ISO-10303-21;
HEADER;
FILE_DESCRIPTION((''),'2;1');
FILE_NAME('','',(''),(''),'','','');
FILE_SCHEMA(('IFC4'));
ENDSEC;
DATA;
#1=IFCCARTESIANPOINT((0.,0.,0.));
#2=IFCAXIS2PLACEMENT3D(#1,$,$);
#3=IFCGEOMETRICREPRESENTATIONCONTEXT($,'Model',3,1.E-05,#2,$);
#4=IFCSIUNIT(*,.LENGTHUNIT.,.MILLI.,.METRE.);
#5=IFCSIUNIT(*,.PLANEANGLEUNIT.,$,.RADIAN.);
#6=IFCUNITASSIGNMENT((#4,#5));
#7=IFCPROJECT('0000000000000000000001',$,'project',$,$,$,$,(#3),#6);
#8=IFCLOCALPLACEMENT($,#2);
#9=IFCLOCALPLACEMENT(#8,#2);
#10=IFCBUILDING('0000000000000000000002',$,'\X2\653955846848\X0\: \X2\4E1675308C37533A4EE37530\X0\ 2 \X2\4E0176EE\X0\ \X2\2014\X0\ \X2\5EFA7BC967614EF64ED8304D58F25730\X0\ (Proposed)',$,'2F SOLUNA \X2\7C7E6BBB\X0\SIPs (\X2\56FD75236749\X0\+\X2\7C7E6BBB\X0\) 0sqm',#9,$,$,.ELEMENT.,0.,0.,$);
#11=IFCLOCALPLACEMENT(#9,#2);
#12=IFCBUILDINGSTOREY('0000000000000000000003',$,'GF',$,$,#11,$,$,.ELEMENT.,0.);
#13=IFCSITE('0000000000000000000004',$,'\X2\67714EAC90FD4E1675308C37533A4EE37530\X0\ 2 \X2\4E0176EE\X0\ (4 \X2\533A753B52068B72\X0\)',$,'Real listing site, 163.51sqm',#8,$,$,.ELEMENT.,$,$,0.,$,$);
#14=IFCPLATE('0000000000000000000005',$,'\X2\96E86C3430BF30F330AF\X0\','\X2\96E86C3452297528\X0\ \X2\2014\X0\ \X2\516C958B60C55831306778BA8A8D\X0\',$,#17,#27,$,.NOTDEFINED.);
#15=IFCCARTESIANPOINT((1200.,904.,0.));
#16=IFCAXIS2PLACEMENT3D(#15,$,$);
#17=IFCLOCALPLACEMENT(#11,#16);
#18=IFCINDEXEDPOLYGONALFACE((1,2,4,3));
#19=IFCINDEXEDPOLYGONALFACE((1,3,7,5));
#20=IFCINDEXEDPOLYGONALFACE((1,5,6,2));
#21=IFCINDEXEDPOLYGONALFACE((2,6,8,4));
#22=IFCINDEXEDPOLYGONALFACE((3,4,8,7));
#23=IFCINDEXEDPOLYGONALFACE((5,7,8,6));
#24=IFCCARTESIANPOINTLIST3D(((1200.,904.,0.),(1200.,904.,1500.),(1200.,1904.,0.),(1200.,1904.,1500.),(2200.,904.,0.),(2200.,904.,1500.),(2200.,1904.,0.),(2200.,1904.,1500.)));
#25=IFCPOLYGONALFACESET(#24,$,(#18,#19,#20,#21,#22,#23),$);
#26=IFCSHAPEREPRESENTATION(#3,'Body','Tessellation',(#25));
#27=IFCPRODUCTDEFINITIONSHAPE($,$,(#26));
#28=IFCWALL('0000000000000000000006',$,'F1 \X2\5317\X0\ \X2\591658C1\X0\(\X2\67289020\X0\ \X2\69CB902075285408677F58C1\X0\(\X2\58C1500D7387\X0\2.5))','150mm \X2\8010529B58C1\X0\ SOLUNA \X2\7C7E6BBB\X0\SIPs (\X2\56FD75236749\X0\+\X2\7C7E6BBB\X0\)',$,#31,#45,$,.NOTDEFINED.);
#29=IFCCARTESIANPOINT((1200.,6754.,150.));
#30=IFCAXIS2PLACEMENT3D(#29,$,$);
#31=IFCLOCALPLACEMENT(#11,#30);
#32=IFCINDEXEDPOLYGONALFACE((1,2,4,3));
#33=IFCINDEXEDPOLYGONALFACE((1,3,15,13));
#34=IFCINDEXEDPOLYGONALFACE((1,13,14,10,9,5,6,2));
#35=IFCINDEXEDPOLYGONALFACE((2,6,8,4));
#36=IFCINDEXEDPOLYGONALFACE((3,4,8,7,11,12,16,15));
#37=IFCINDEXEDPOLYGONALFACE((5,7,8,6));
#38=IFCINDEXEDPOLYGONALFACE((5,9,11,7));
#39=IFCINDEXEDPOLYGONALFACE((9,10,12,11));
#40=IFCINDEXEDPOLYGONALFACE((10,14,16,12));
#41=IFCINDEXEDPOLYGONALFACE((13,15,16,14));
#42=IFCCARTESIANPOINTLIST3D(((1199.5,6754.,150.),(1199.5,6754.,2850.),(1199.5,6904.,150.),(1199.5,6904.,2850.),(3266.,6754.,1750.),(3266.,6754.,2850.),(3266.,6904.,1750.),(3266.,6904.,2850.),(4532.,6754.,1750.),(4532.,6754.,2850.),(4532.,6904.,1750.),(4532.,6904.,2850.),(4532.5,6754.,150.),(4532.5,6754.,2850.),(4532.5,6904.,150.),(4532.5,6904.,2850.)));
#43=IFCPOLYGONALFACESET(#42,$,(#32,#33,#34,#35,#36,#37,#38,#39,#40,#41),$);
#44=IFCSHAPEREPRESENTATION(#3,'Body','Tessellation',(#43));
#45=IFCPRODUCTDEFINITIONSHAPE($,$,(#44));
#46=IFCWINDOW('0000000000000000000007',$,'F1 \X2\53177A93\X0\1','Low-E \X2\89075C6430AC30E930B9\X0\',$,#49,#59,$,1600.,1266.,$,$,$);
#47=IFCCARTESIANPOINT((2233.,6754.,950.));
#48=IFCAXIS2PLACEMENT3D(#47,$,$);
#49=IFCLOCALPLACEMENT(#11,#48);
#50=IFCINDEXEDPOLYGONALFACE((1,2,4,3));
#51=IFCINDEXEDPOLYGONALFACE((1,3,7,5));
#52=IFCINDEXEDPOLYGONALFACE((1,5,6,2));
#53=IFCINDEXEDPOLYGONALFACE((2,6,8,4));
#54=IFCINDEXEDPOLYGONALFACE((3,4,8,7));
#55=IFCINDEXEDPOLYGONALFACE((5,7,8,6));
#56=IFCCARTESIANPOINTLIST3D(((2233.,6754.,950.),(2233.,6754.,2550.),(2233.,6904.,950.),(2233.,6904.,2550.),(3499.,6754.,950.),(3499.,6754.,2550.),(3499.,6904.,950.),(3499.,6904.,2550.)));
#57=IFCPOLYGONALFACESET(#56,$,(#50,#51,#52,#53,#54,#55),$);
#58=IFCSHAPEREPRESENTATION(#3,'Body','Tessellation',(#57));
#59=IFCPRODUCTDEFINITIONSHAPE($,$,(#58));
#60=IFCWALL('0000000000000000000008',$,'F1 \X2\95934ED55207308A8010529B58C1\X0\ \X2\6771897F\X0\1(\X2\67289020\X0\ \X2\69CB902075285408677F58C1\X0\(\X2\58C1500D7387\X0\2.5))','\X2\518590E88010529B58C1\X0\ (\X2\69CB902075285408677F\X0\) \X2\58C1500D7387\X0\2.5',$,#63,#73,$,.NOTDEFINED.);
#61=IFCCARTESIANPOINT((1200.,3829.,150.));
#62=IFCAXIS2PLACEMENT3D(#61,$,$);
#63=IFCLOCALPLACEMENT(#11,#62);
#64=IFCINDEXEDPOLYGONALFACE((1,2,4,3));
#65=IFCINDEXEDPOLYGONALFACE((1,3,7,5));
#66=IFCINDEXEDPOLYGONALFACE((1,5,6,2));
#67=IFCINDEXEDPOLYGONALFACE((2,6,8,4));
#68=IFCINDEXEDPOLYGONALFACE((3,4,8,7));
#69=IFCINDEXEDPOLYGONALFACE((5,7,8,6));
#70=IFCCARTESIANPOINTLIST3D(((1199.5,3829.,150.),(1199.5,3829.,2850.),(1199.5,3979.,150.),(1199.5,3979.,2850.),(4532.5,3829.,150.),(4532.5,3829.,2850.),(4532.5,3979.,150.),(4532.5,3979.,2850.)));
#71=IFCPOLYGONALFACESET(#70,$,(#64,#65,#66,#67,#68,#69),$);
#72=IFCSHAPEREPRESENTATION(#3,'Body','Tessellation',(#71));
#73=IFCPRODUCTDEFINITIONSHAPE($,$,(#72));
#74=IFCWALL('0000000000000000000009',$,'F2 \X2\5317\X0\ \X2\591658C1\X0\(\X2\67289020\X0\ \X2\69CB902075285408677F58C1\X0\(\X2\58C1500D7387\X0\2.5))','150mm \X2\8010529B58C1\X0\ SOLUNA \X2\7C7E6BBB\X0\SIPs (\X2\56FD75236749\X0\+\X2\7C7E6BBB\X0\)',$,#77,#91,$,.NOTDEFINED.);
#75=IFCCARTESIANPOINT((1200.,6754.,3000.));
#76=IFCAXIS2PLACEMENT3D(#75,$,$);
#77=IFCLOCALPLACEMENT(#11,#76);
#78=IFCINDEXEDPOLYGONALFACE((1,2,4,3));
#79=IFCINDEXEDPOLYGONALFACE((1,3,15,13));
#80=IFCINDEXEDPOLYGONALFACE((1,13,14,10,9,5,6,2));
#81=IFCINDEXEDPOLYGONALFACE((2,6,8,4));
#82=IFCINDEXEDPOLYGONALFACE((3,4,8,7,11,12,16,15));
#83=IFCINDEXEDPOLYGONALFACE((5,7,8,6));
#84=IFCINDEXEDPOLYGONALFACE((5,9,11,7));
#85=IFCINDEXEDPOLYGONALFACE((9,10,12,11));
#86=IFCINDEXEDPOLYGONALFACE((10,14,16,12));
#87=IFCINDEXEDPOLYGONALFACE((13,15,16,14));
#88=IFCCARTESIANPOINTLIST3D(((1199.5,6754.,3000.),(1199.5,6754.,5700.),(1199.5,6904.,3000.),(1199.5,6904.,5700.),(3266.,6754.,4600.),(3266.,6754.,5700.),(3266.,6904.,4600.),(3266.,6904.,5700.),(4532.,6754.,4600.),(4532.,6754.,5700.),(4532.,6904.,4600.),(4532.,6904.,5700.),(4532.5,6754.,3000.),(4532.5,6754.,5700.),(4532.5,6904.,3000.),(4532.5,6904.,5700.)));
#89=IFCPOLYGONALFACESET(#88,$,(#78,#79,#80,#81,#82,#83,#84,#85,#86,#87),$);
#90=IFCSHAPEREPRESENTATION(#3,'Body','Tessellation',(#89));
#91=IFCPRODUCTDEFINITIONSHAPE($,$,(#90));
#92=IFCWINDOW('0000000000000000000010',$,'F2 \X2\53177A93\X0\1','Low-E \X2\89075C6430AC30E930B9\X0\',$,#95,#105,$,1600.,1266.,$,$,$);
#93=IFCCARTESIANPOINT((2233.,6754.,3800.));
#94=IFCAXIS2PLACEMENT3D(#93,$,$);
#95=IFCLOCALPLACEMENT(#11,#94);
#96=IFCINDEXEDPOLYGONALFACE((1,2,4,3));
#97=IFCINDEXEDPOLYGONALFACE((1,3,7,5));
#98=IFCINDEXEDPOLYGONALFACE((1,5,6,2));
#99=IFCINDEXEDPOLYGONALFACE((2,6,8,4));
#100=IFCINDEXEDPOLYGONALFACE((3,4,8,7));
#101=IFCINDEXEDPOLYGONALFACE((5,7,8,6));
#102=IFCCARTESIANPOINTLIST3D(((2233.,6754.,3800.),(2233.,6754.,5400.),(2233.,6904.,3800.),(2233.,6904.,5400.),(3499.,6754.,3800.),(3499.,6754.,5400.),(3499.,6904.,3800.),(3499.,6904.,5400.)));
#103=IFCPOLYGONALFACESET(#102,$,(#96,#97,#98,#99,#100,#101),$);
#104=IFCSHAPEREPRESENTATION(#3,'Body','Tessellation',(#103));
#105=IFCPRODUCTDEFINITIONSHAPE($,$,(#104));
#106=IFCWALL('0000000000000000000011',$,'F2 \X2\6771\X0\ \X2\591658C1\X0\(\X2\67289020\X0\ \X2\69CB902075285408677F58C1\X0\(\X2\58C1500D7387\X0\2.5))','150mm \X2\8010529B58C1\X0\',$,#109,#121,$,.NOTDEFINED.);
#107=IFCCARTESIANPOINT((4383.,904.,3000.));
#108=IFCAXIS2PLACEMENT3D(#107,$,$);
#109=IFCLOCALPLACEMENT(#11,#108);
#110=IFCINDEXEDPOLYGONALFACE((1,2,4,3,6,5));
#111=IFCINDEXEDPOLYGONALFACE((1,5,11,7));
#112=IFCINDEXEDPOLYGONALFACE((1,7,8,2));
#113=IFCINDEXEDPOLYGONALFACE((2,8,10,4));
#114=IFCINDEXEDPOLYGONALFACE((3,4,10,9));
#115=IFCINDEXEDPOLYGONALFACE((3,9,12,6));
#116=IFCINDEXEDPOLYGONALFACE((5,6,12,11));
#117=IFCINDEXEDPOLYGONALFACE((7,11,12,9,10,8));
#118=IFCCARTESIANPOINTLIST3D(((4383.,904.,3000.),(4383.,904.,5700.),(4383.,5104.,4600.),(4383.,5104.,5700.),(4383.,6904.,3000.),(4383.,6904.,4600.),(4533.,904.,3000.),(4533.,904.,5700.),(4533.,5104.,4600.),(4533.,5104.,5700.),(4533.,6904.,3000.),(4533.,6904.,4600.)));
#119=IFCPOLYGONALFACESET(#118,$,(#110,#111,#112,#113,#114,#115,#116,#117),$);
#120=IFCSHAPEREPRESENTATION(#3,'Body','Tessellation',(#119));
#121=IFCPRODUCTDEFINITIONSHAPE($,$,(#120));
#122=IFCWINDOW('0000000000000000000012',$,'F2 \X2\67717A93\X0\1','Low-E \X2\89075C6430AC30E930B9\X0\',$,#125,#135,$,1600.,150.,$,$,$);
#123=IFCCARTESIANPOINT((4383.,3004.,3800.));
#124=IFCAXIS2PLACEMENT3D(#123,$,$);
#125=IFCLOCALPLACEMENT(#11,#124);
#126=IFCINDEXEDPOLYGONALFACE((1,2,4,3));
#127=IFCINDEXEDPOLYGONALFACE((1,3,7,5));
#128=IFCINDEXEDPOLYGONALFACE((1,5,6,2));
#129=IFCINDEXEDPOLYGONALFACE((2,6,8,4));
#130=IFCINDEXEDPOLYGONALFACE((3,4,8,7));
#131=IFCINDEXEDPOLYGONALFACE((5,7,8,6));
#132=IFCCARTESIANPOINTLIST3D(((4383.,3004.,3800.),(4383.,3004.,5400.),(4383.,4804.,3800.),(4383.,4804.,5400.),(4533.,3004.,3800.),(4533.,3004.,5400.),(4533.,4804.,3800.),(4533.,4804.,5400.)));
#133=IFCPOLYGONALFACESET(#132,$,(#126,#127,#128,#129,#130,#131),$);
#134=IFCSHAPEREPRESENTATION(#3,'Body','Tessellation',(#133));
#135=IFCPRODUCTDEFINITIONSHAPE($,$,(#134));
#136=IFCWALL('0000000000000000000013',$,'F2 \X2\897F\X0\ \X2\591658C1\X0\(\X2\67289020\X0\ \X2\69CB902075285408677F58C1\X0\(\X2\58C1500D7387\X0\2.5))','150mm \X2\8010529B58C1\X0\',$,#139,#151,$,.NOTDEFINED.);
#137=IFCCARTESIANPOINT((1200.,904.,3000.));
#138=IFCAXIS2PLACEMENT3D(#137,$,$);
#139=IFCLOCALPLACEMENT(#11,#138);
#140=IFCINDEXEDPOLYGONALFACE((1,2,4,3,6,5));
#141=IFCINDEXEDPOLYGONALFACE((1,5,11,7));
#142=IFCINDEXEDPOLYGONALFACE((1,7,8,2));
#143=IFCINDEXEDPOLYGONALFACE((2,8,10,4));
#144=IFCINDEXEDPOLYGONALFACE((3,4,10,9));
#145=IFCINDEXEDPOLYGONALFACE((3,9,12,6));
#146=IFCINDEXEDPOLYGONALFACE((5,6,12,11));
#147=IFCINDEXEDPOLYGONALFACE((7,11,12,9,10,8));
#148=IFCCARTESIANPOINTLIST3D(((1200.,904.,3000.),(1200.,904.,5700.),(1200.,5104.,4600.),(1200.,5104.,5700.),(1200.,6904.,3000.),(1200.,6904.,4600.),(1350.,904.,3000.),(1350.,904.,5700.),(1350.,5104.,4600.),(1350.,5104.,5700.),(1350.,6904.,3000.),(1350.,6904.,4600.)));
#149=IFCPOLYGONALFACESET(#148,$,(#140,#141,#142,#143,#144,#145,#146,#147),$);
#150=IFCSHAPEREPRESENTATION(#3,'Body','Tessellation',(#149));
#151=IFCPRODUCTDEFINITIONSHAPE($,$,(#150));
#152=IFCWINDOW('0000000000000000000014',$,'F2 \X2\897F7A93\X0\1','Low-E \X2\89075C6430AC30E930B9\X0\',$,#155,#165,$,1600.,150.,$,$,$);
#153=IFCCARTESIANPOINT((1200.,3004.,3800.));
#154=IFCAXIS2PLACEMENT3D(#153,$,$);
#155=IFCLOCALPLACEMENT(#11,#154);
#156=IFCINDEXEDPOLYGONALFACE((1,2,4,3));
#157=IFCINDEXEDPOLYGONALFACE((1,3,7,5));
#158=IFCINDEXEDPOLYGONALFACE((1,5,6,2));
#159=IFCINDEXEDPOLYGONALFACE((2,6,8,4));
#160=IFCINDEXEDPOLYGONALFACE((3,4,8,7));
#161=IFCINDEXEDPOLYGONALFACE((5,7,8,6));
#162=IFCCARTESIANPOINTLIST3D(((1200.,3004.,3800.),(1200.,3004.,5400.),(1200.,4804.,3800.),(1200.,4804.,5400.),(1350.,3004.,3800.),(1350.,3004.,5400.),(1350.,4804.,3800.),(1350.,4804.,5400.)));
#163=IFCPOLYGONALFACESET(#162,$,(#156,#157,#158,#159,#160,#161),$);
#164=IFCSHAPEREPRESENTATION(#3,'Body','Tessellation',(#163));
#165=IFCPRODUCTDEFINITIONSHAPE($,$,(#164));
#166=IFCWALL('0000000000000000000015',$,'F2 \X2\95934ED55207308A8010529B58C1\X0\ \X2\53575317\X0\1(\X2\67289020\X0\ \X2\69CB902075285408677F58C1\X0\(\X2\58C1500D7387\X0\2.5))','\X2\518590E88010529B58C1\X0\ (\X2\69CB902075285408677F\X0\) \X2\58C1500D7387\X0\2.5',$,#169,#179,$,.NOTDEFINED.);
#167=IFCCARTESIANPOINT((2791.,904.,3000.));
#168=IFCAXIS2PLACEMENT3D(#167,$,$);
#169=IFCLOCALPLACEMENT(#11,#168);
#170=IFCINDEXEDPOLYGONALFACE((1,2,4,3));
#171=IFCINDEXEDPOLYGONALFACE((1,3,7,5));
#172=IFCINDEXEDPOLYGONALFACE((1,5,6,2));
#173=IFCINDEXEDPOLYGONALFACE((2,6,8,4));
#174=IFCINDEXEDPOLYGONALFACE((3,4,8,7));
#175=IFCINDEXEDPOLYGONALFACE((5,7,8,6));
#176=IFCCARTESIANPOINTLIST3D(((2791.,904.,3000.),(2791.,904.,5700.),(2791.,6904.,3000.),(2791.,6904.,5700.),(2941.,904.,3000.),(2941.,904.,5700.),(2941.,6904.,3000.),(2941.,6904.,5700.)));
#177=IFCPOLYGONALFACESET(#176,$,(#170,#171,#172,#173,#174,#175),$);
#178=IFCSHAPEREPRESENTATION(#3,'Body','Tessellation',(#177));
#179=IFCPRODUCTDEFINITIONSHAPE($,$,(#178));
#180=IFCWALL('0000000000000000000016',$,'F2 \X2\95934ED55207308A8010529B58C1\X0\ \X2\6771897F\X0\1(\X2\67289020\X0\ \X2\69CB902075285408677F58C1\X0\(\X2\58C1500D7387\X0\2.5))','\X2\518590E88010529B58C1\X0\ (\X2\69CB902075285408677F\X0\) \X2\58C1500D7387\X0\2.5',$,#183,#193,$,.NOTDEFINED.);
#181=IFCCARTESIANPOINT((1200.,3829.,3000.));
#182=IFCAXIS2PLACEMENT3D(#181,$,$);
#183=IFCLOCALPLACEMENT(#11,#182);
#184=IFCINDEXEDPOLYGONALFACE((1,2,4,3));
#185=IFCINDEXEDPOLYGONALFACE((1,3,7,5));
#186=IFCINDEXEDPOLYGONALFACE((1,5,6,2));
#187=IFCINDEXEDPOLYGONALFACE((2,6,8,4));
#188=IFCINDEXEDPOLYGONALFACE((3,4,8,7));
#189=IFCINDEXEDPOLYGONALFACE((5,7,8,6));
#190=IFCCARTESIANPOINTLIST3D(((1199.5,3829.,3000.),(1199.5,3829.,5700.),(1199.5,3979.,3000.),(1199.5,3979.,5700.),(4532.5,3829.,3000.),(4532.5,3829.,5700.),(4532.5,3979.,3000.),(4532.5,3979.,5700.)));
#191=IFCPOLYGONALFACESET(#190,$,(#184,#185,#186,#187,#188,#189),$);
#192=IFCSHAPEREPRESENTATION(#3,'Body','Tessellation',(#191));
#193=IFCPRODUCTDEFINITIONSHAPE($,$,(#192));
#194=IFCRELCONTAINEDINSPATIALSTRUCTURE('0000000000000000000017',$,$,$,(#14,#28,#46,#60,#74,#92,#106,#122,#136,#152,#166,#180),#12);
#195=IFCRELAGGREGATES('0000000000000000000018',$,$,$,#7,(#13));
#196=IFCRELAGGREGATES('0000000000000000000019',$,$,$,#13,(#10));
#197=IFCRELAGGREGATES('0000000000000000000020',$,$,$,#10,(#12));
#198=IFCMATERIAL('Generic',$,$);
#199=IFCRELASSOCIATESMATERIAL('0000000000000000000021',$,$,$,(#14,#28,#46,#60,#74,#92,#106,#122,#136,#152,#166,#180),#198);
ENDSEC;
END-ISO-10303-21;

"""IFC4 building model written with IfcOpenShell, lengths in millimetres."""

from ifc_helpers import new_model, si_unit, frame, frame_2d, origin, place, context, project, spatial, rectangle, extrude, material, element, fill, save


model = new_model("IFC4")

# Units and contexts
model_context = context("Model", 3, precision=1e-05, world=origin())
ifc_project = project(units=[si_unit("LENGTHUNIT", "METRE", prefix="MILLI"), si_unit("PLANEANGLEUNIT", "RADIAN")], contexts=[model_context])

# Site, building, storey
site_placement = place(None, origin())
site = spatial("IfcSite", under=ifc_project, at=site_placement, Name="東京都世田谷区代田 2 丁目 (4 区画分譲)", ObjectType="Real listing site, 163.51sqm", CompositionType="ELEMENT", RefElevation=0.0)
building_placement = place(site_placement, origin())
building = spatial("IfcBuilding", under=site, at=building_placement, Name="改善案: 世田谷区代田 2 丁目 — 建築条件付き売地 (Proposed)", ObjectType="2F SOLUNA 籾殻SIPs (国産杉+籾殻) 0sqm", CompositionType="ELEMENT", ElevationOfRefHeight=0.0, ElevationOfTerrain=0.0)
storey_placement = place(building_placement, origin())
storey = spatial("IfcBuildingStorey", under=building, at=storey_placement, Name="GF", CompositionType="ELEMENT", Elevation=0.0)

# Plate
ifc_material_1 = material(Name="Generic")
plate_placement = place(storey_placement, frame((1200.0, 904.0, 0.0)))
element("IfcPlate", 1, at=plate_placement, inside=storey, material=ifc_material_1, Name="雨水タンク", Description="雨水利用 — 公開情報で確認", PredefinedType="NOTDEFINED", context=model_context, shape_type="SweptSolid", body=[
    extrude(rectangle(XDim=1000.0, YDim=1000.0, at=frame_2d((500.0, 500.0))), frame((1200.0, 904.0, 0.0)), (0.0, 0.0, 1.0), 1500.0),
])

# Wall, opening, window
wall_1_placement = place(storey_placement, frame((1200.0, 6754.0, 150.0)))
wall_1 = element("IfcWall", 2, at=wall_1_placement, inside=storey, material=ifc_material_1, Name="F1 北 外壁(木造 構造用合板壁(壁倍率2.5))", Description="150mm 耐力壁 SOLUNA 籾殻SIPs (国産杉+籾殻)", PredefinedType="NOTDEFINED", context=model_context, shape_type="SweptSolid", body=[
    extrude(rectangle(XDim=3333.0, YDim=150.0, at=frame_2d((1666.0, 75.0))), frame((1200.0, 6754.0, 150.0)), (0.0, 0.0, 1.0), 2700.0),
])
opening_1_placement = place(storey_placement, frame((2233.0, 6754.0, 950.0)))
opening_1 = element("IfcOpeningElement", 3, at=opening_1_placement, cuts=wall_1, PredefinedType="NOTDEFINED", context=model_context, shape_type="SweptSolid", body=[
    extrude(rectangle(XDim=1266.0, YDim=150.0, at=frame_2d((633.0, 75.0))), frame((2233.0, 6754.0, 950.0)), (0.0, 0.0, 1.0), 1600.0),
])
window_1_placement = place(storey_placement, frame((2233.0, 6754.0, 950.0)))
window_1 = element("IfcWindow", 4, at=window_1_placement, inside=storey, material=ifc_material_1, Name="F1 北窓1", Description="Low-E 複層ガラス", OverallHeight=1600.0, OverallWidth=1266.0, context=model_context, shape_type="SweptSolid", body=[
    extrude(rectangle(XDim=1266.0, YDim=150.0, at=frame_2d((633.0, 75.0))), frame((2233.0, 6754.0, 950.0)), (0.0, 0.0, 1.0), 1600.0),
])
fill(opening_1, window_1)

# Wall
wall_2_placement = place(storey_placement, frame((1200.0, 3829.0, 150.0)))
element("IfcWall", 5, at=wall_2_placement, inside=storey, material=ifc_material_1, Name="F1 間仕切り耐力壁 東西1(木造 構造用合板壁(壁倍率2.5))", Description="内部耐力壁 (構造用合板) 壁倍率2.5", PredefinedType="NOTDEFINED", context=model_context, shape_type="SweptSolid", body=[
    extrude(rectangle(XDim=3333.0, YDim=150.0, at=frame_2d((1666.0, 75.0))), frame((1200.0, 3829.0, 150.0)), (0.0, 0.0, 1.0), 2700.0),
])

# Walls, openings, windows
wall_3_placement = place(storey_placement, frame((1200.0, 6754.0, 3000.0)))
wall_3 = element("IfcWall", 6, at=wall_3_placement, inside=storey, material=ifc_material_1, Name="F2 北 外壁(木造 構造用合板壁(壁倍率2.5))", Description="150mm 耐力壁 SOLUNA 籾殻SIPs (国産杉+籾殻)", PredefinedType="NOTDEFINED", context=model_context, shape_type="SweptSolid", body=[
    extrude(rectangle(XDim=3333.0, YDim=150.0, at=frame_2d((1666.0, 75.0))), frame((1200.0, 6754.0, 3000.0)), (0.0, 0.0, 1.0), 2700.0),
])
opening_2_placement = place(storey_placement, frame((2233.0, 6754.0, 3800.0)))
opening_2 = element("IfcOpeningElement", 7, at=opening_2_placement, cuts=wall_3, PredefinedType="NOTDEFINED", context=model_context, shape_type="SweptSolid", body=[
    extrude(rectangle(XDim=1266.0, YDim=150.0, at=frame_2d((633.0, 75.0))), frame((2233.0, 6754.0, 3800.0)), (0.0, 0.0, 1.0), 1600.0),
])
window_2_placement = place(storey_placement, frame((2233.0, 6754.0, 3800.0)))
window_2 = element("IfcWindow", 8, at=window_2_placement, inside=storey, material=ifc_material_1, Name="F2 北窓1", Description="Low-E 複層ガラス", OverallHeight=1600.0, OverallWidth=1266.0, context=model_context, shape_type="SweptSolid", body=[
    extrude(rectangle(XDim=1266.0, YDim=150.0, at=frame_2d((633.0, 75.0))), frame((2233.0, 6754.0, 3800.0)), (0.0, 0.0, 1.0), 1600.0),
])
fill(opening_2, window_2)
wall_4_placement = place(storey_placement, frame((4383.0, 904.0, 3000.0)))
wall_4 = element("IfcWall", 9, at=wall_4_placement, inside=storey, material=ifc_material_1, Name="F2 東 外壁(木造 構造用合板壁(壁倍率2.5))", Description="150mm 耐力壁", PredefinedType="NOTDEFINED", context=model_context, shape_type="SweptSolid", body=[
    extrude(rectangle(XDim=150.0, YDim=6000.0, at=frame_2d((75.0, 3000.0))), frame((4383.0, 904.0, 3000.0)), (0.0, 0.0, 1.0), 2700.0),
])
opening_3_placement = place(storey_placement, frame((4383.0, 3004.0, 3800.0)))
opening_3 = element("IfcOpeningElement", 10, at=opening_3_placement, cuts=wall_4, PredefinedType="NOTDEFINED", context=model_context, shape_type="SweptSolid", body=[
    extrude(rectangle(XDim=150.0, YDim=1800.0, at=frame_2d((75.0, 900.0))), frame((4383.0, 3004.0, 3800.0)), (0.0, 0.0, 1.0), 1600.0),
])
window_3_placement = place(storey_placement, frame((4383.0, 3004.0, 3800.0)))
window_3 = element("IfcWindow", 11, at=window_3_placement, inside=storey, material=ifc_material_1, Name="F2 東窓1", Description="Low-E 複層ガラス", OverallHeight=1600.0, OverallWidth=150.0, context=model_context, shape_type="SweptSolid", body=[
    extrude(rectangle(XDim=150.0, YDim=1800.0, at=frame_2d((75.0, 900.0))), frame((4383.0, 3004.0, 3800.0)), (0.0, 0.0, 1.0), 1600.0),
])
fill(opening_3, window_3)
wall_5_placement = place(storey_placement, frame((1200.0, 904.0, 3000.0)))
wall_5 = element("IfcWall", 12, at=wall_5_placement, inside=storey, material=ifc_material_1, Name="F2 西 外壁(木造 構造用合板壁(壁倍率2.5))", Description="150mm 耐力壁", PredefinedType="NOTDEFINED", context=model_context, shape_type="SweptSolid", body=[
    extrude(rectangle(XDim=150.0, YDim=6000.0, at=frame_2d((75.0, 3000.0))), frame((1200.0, 904.0, 3000.0)), (0.0, 0.0, 1.0), 2700.0),
])
opening_4_placement = place(storey_placement, frame((1200.0, 3004.0, 3800.0)))
opening_4 = element("IfcOpeningElement", 13, at=opening_4_placement, cuts=wall_5, PredefinedType="NOTDEFINED", context=model_context, shape_type="SweptSolid", body=[
    extrude(rectangle(XDim=150.0, YDim=1800.0, at=frame_2d((75.0, 900.0))), frame((1200.0, 3004.0, 3800.0)), (0.0, 0.0, 1.0), 1600.0),
])
window_4_placement = place(storey_placement, frame((1200.0, 3004.0, 3800.0)))
window_4 = element("IfcWindow", 14, at=window_4_placement, inside=storey, material=ifc_material_1, Name="F2 西窓1", Description="Low-E 複層ガラス", OverallHeight=1600.0, OverallWidth=150.0, context=model_context, shape_type="SweptSolid", body=[
    extrude(rectangle(XDim=150.0, YDim=1800.0, at=frame_2d((75.0, 900.0))), frame((1200.0, 3004.0, 3800.0)), (0.0, 0.0, 1.0), 1600.0),
])
fill(opening_4, window_4)

# Walls
wall_6_placement = place(storey_placement, frame((2791.0, 904.0, 3000.0)))
element("IfcWall", 15, at=wall_6_placement, inside=storey, material=ifc_material_1, Name="F2 間仕切り耐力壁 南北1(木造 構造用合板壁(壁倍率2.5))", Description="内部耐力壁 (構造用合板) 壁倍率2.5", PredefinedType="NOTDEFINED", context=model_context, shape_type="SweptSolid", body=[
    extrude(rectangle(XDim=150.0, YDim=6000.0, at=frame_2d((75.0, 3000.0))), frame((2791.0, 904.0, 3000.0)), (0.0, 0.0, 1.0), 2700.0),
])
wall_7_placement = place(storey_placement, frame((1200.0, 3829.0, 3000.0)))
element("IfcWall", 16, at=wall_7_placement, inside=storey, material=ifc_material_1, Name="F2 間仕切り耐力壁 東西1(木造 構造用合板壁(壁倍率2.5))", Description="内部耐力壁 (構造用合板) 壁倍率2.5", PredefinedType="NOTDEFINED", context=model_context, shape_type="SweptSolid", body=[
    extrude(rectangle(XDim=3333.0, YDim=150.0, at=frame_2d((1666.0, 75.0))), frame((1200.0, 3829.0, 3000.0)), (0.0, 0.0, 1.0), 2700.0),
])

save(model, "model.ifc")
